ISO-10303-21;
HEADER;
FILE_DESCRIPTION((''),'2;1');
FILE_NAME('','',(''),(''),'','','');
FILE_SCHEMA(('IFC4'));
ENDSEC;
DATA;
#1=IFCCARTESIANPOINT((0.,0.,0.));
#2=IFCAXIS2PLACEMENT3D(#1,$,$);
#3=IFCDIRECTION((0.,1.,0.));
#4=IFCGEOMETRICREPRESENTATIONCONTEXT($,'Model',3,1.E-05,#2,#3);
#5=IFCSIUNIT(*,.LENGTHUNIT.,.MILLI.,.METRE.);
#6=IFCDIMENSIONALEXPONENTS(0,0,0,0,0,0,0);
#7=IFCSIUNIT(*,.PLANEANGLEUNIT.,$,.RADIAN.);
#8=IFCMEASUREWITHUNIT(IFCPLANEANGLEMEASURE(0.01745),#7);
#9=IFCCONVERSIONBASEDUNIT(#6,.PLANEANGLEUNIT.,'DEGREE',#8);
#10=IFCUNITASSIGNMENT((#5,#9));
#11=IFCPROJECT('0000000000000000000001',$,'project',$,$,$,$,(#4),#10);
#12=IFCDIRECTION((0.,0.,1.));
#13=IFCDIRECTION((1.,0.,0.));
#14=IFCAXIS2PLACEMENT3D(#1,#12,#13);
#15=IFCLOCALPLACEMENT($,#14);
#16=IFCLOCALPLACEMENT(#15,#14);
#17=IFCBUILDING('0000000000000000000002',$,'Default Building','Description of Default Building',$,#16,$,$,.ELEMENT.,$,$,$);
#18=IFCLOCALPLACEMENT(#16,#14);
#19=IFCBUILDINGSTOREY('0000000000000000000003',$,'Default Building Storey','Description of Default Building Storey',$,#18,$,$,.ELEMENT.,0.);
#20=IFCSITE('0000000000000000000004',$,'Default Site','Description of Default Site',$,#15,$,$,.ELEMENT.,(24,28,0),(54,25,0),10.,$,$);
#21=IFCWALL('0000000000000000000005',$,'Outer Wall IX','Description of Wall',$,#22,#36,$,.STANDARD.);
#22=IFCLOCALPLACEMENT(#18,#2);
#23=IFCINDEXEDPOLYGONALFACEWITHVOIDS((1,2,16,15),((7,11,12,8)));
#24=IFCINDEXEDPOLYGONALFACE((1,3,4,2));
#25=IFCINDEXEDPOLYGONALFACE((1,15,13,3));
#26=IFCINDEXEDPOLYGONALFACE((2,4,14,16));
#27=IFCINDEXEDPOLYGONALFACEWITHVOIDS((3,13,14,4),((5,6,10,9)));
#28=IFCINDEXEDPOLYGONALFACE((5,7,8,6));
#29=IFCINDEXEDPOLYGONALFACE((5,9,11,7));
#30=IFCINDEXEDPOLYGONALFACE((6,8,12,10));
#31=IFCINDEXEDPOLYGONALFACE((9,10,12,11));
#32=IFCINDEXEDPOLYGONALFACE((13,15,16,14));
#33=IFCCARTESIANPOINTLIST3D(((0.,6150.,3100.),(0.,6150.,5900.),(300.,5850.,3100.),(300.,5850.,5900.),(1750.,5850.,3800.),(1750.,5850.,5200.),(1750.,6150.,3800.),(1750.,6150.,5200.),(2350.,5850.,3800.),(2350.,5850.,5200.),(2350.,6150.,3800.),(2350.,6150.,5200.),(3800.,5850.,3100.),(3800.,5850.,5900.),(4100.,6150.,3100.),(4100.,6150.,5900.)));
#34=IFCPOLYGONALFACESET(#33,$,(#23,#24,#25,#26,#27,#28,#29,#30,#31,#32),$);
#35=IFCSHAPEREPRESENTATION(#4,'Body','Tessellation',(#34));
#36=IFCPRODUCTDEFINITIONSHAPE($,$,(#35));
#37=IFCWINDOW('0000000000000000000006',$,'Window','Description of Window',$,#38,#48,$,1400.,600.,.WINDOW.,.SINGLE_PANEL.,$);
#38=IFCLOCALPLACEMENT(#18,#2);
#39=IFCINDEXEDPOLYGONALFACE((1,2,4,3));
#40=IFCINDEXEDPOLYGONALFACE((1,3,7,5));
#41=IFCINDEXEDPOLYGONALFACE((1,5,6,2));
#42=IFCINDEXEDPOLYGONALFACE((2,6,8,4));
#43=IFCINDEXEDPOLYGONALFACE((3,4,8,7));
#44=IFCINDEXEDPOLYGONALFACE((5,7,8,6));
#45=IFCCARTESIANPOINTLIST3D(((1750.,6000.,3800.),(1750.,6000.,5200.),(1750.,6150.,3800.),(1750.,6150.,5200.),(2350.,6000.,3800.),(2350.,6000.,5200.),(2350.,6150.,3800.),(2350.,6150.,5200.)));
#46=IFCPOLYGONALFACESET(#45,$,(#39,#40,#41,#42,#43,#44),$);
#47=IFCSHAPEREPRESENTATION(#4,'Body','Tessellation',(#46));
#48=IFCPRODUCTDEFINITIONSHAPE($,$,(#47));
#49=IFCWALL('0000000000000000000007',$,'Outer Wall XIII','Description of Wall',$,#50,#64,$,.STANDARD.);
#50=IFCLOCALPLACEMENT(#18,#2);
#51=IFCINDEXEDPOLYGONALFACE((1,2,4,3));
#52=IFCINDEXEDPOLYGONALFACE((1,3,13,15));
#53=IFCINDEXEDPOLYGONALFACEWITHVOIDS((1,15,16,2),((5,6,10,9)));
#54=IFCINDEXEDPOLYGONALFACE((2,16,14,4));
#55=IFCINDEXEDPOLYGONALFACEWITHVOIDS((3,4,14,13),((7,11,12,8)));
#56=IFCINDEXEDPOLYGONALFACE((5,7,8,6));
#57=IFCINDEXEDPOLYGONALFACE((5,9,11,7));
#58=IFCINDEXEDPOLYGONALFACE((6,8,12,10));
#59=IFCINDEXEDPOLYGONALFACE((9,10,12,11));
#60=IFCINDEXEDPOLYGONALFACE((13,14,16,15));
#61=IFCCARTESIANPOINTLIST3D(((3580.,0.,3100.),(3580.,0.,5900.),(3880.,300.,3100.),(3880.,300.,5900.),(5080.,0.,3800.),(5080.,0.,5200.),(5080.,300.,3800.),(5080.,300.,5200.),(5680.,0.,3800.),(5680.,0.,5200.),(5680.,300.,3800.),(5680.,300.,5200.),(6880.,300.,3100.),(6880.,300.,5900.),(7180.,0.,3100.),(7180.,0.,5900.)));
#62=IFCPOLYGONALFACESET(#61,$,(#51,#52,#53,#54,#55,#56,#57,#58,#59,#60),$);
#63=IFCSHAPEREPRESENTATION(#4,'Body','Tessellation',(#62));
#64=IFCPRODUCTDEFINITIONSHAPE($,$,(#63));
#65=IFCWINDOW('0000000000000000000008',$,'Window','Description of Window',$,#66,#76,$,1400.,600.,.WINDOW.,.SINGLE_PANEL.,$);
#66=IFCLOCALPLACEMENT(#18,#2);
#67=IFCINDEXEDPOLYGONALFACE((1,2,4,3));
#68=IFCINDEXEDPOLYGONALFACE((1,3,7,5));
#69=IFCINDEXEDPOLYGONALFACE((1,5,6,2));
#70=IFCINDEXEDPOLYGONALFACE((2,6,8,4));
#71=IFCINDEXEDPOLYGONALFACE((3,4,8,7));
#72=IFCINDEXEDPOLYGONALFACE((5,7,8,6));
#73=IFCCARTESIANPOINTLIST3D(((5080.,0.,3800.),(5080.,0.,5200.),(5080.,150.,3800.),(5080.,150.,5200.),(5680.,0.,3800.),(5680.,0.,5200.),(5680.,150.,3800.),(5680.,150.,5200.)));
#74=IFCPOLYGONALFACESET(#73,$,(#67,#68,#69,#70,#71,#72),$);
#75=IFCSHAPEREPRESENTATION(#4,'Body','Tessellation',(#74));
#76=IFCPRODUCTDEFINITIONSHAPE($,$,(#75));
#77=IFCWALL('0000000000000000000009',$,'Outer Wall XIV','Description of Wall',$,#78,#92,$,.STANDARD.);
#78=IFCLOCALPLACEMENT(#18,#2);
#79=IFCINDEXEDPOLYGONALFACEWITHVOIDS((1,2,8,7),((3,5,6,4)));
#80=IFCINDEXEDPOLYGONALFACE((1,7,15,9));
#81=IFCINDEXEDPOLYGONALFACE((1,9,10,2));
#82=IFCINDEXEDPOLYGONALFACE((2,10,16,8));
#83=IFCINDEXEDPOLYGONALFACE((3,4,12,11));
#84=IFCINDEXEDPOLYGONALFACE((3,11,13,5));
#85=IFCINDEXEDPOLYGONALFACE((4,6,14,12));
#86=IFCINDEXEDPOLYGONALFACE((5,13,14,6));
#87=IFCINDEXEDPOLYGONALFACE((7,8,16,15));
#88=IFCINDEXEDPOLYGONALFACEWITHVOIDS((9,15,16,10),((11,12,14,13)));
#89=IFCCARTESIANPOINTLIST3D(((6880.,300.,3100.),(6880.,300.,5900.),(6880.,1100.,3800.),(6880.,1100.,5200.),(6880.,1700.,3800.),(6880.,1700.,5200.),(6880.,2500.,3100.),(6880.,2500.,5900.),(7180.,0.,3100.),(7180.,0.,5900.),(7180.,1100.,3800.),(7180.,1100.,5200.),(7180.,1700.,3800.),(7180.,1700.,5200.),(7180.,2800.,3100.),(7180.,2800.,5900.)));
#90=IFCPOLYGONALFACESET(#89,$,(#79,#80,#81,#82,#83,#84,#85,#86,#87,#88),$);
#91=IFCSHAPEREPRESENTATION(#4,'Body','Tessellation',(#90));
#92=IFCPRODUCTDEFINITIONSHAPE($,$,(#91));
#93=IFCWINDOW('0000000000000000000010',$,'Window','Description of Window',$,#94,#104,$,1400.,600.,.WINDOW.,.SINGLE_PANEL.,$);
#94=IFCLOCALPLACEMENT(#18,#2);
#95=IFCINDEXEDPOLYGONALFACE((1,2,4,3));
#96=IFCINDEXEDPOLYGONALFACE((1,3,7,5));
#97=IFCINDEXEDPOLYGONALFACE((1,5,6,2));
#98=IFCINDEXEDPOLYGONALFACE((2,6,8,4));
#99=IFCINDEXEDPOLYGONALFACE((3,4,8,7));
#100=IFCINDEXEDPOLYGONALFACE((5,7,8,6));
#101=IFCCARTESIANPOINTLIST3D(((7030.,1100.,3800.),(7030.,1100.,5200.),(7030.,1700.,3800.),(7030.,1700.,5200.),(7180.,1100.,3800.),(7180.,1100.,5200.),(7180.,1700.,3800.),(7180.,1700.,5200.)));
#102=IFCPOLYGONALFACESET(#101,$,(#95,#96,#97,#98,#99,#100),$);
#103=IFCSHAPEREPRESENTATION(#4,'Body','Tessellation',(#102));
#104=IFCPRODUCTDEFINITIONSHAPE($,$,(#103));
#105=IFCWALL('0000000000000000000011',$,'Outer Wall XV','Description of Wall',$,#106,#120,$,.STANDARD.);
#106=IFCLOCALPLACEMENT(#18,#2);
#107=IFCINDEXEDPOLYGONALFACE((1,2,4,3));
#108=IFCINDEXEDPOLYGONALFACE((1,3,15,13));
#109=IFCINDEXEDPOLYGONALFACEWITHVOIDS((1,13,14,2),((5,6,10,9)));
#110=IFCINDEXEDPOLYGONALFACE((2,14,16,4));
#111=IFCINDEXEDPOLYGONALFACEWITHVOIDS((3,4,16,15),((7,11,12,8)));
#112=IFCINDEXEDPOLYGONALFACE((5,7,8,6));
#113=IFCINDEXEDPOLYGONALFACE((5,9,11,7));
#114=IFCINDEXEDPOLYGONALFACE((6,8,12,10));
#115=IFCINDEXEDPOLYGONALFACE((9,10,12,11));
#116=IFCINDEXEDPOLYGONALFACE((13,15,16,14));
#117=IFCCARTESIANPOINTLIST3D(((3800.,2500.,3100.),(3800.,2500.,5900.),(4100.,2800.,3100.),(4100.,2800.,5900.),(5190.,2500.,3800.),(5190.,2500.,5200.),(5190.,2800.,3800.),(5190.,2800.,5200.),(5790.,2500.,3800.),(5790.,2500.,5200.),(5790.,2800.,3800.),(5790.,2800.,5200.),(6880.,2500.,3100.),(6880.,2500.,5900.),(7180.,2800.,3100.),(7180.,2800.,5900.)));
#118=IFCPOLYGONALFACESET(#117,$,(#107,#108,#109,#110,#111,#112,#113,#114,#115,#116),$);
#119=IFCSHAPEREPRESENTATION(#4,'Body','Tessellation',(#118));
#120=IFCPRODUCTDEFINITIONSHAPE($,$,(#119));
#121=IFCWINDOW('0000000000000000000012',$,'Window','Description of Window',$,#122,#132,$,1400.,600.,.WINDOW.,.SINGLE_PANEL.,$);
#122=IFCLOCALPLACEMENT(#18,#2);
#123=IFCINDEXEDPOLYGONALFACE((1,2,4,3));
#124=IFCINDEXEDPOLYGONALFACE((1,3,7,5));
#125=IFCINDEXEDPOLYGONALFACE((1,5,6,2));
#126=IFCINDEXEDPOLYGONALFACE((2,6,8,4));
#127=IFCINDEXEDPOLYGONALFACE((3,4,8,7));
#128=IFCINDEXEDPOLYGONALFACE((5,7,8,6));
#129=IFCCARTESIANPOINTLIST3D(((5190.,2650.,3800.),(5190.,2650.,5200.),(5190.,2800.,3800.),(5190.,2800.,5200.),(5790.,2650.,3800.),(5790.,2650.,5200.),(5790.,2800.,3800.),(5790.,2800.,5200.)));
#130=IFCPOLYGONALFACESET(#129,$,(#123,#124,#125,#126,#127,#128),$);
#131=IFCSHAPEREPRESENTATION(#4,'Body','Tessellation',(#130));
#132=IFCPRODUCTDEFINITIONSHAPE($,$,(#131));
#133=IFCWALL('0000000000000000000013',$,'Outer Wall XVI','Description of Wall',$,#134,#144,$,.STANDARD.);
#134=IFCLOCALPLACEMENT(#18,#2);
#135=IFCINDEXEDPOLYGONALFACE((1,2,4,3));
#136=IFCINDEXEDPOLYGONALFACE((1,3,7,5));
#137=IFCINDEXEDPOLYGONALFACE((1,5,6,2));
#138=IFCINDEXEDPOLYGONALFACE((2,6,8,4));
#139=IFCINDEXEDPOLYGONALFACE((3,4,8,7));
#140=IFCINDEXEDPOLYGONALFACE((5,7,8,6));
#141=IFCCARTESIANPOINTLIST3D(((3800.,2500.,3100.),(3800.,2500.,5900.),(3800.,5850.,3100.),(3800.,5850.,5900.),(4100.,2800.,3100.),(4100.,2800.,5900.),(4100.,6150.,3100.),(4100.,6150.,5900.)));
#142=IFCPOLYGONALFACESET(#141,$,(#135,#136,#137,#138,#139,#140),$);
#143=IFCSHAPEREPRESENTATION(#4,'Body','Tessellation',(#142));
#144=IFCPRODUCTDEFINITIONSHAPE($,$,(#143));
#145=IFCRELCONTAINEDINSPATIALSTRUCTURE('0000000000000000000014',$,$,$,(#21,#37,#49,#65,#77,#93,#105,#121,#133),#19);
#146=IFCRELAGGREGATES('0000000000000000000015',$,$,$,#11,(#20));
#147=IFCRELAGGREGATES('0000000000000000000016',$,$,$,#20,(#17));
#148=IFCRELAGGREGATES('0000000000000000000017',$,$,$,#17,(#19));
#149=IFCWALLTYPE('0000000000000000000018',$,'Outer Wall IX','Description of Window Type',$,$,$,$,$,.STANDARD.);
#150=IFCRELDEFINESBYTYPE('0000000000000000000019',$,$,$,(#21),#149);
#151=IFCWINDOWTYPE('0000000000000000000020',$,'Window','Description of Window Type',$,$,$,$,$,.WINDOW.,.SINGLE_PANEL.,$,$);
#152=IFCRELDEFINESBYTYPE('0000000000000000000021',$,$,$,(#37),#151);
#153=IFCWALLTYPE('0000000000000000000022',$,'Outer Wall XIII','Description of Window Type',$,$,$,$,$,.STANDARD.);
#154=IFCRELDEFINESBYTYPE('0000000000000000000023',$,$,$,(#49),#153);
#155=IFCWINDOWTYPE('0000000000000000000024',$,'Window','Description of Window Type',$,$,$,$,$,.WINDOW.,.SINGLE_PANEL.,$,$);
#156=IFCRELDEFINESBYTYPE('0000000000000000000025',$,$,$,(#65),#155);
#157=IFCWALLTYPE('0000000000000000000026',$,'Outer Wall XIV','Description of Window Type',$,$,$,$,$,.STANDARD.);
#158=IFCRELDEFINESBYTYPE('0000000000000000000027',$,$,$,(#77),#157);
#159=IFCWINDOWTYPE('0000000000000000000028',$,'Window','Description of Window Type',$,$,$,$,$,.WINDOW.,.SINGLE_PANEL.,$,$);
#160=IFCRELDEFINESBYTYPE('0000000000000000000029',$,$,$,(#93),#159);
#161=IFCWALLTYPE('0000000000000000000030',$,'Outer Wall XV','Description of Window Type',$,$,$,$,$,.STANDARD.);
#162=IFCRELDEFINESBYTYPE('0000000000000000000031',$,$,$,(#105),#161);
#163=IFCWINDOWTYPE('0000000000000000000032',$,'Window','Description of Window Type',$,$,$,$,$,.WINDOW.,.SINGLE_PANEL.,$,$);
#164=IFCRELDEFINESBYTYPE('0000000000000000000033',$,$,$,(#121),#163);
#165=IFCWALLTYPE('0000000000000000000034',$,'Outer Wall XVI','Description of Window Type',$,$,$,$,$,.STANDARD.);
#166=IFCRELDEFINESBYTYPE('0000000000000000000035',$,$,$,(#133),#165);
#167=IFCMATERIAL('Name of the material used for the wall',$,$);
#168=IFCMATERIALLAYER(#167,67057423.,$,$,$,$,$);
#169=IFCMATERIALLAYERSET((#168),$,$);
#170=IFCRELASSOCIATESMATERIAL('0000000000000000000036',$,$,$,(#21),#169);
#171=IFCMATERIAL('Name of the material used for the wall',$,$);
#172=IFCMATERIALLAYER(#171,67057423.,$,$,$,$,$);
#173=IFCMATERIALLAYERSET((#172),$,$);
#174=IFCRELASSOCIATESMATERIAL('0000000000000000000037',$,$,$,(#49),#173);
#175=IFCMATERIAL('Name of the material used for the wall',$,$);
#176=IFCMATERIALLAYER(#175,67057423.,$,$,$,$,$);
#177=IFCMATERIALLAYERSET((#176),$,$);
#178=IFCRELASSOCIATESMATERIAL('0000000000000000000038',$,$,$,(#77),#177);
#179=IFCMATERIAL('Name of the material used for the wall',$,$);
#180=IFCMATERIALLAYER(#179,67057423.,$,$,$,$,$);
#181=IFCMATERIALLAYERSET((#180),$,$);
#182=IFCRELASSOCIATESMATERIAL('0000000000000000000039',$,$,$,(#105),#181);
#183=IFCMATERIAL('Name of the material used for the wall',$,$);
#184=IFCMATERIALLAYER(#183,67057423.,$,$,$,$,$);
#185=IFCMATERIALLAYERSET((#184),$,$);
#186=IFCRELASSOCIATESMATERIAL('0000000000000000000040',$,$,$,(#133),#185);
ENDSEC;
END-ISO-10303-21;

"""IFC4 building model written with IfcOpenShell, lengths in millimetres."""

from ifc_helpers import new_model, entity, si_unit, converted_unit, direction, frame, origin, origin_with_axes, place, context, project, spatial, polyline, outline, extrude, material, layer, layer_set, layer_usage, type_object, element, fill, save


model = new_model("IFC4")

# Units and contexts
model_context = context("Model", 3, precision=1e-05, world=origin(), true_north=direction((0.0, 1.0, 0.0)))
ifc_project = project(units=[si_unit("LENGTHUNIT", "METRE", prefix="MILLI"), converted_unit("PLANEANGLEUNIT", "DEGREE", entity("IfcPlaneAngleMeasure", 0.01745), si_unit("PLANEANGLEUNIT", "RADIAN"), dimensions=[0, 0, 0, 0, 0, 0, 0])], contexts=[model_context])

# Site, building, storey
site_placement = place(None, origin_with_axes())
site = spatial("IfcSite", under=ifc_project, at=site_placement, Name="Default Site", Description="Description of Default Site", CompositionType="ELEMENT", RefLatitude=(24, 28, 0), RefLongitude=(54, 25, 0), RefElevation=10.0)
building_placement = place(site_placement, origin_with_axes())
building = spatial("IfcBuilding", under=site, at=building_placement, Name="Default Building", Description="Description of Default Building", CompositionType="ELEMENT")
storey_placement = place(building_placement, origin_with_axes())
storey = spatial("IfcBuildingStorey", under=building, at=storey_placement, Name="Default Building Storey", Description="Description of Default Building Storey", CompositionType="ELEMENT", Elevation=0.0)

# Walls, openings, windows
ifc_material_1 = material(Name="Name of the material used for the wall")
ifc_layer_1 = layer(ifc_material_1, 67057423.0)
ifc_layer_set_1 = layer_set([ifc_layer_1])
ifc_layer_usage_1 = layer_usage(ifc_layer_set_1, "AXIS2", "POSITIVE", -33528711.5)
wall_type_1 = type_object("IfcWallType", Name="Outer Wall IX", Description="Description of Window Type", PredefinedType="STANDARD")
wall_1_placement = place(storey_placement, frame((3950.0, 6000.0, 3100.0), z_axis=(0.0, 0.0, 1.0), x_axis=(-1.0, 0.0, 0.0)))
wall_1 = element("IfcWall", 1, at=wall_1_placement, inside=storey, type_object=wall_type_1, material=ifc_layer_usage_1, Name="Outer Wall IX", Description="Description of Wall", PredefinedType="STANDARD", context=model_context, shape_type="SweptSolid", body=[
    extrude(outline(polyline([(-150.0, -150.0), (150.0, 150.0), (3650.0, 150.0), (3950.0, -150.0), (-150.0, -150.0)])), origin_with_axes(), (0.0, 0.0, 1.0), 2800.0),
])
opening_1_placement = place(wall_1_placement, frame((1600.0, -150.0, 700.0), z_axis=(0.0, 0.0, 1.0), x_axis=(1.0, 0.0, 0.0)))
opening_1 = element("IfcOpeningElement", 2, at=opening_1_placement, cuts=wall_1, context=model_context, shape_type="SweptSolid", body=[
    extrude(outline(polyline([(0.0, 0.0), (0.0, 300.0), (600.0, 300.0), (600.0, 0.0), (0.0, 0.0)])), origin_with_axes(), (0.0, 0.0, 1.0), 1400.0),
])
window_type_1 = type_object("IfcWindowType", Name="Window", Description="Description of Window Type", PartitioningType="SINGLE_PANEL", PredefinedType="WINDOW")
window_1_placement = place(opening_1_placement, origin_with_axes())
window_1 = element("IfcWindow", 3, at=window_1_placement, inside=storey, type_object=window_type_1, Name="Window", Description="Description of Window", OverallHeight=1400.0, OverallWidth=600.0, PartitioningType="SINGLE_PANEL", PredefinedType="WINDOW", context=model_context, shape_type="SweptSolid", body=[
    extrude(outline(polyline([(0.0, 0.0), (0.0, 150.0), (600.0, 150.0), (600.0, 0.0), (0.0, 0.0)])), origin_with_axes(), (0.0, 0.0, 1.0), 1400.0),
])
fill(opening_1, window_1)
ifc_material_2 = material(Name="Name of the material used for the wall")
ifc_layer_2 = layer(ifc_material_2, 67057423.0)
ifc_layer_set_2 = layer_set([ifc_layer_2])
ifc_layer_usage_2 = layer_usage(ifc_layer_set_2, "AXIS2", "POSITIVE", -33528711.5)
wall_type_2 = type_object("IfcWallType", Name="Outer Wall XIII", Description="Description of Window Type", PredefinedType="STANDARD")
wall_2_placement = place(storey_placement, frame((3730.0, 150.0, 3100.0), z_axis=(0.0, 0.0, 1.0), x_axis=(1.0, 0.0, 0.0)))
wall_2 = element("IfcWall", 4, at=wall_2_placement, inside=storey, type_object=wall_type_2, material=ifc_layer_usage_2, Name="Outer Wall XIII", Description="Description of Wall", PredefinedType="STANDARD", context=model_context, shape_type="SweptSolid", body=[
    extrude(outline(polyline([(-150.0, -150.0), (150.0, 150.0), (3150.0, 150.0), (3450.0, -150.0), (-150.0, -150.0)])), origin_with_axes(), (0.0, 0.0, 1.0), 2800.0),
])
opening_2_placement = place(wall_2_placement, frame((1350.0, -150.0, 700.0), z_axis=(0.0, 0.0, 1.0), x_axis=(1.0, 0.0, 0.0)))
opening_2 = element("IfcOpeningElement", 5, at=opening_2_placement, cuts=wall_2, context=model_context, shape_type="SweptSolid", body=[
    extrude(outline(polyline([(0.0, 0.0), (0.0, 300.0), (600.0, 300.0), (600.0, 0.0), (0.0, 0.0)])), origin_with_axes(), (0.0, 0.0, 1.0), 1400.0),
])
window_type_2 = type_object("IfcWindowType", Name="Window", Description="Description of Window Type", PartitioningType="SINGLE_PANEL", PredefinedType="WINDOW")
window_2_placement = place(opening_2_placement, origin_with_axes())
window_2 = element("IfcWindow", 6, at=window_2_placement, inside=storey, type_object=window_type_2, Name="Window", Description="Description of Window", OverallHeight=1400.0, OverallWidth=600.0, PartitioningType="SINGLE_PANEL", PredefinedType="WINDOW", context=model_context, shape_type="SweptSolid", body=[
    extrude(outline(polyline([(0.0, 0.0), (0.0, 150.0), (600.0, 150.0), (600.0, 0.0), (0.0, 0.0)])), origin_with_axes(), (0.0, 0.0, 1.0), 1400.0),
])
fill(opening_2, window_2)
ifc_material_3 = material(Name="Name of the material used for the wall")
ifc_layer_3 = layer(ifc_material_3, 67057423.0)
ifc_layer_set_3 = layer_set([ifc_layer_3])
ifc_layer_usage_3 = layer_usage(ifc_layer_set_3, "AXIS2", "POSITIVE", -33528711.5)
wall_type_3 = type_object("IfcWallType", Name="Outer Wall XIV", Description="Description of Window Type", PredefinedType="STANDARD")
wall_3_placement = place(storey_placement, frame((7030.0, 150.0, 3100.0), z_axis=(0.0, 0.0, 1.0), x_axis=(0.0, 1.0, 0.0)))
wall_3 = element("IfcWall", 7, at=wall_3_placement, inside=storey, type_object=wall_type_3, material=ifc_layer_usage_3, Name="Outer Wall XIV", Description="Description of Wall", PredefinedType="STANDARD", context=model_context, shape_type="SweptSolid", body=[
    extrude(outline(polyline([(-150.0, -150.0), (150.0, 150.0), (2350.0, 150.0), (2650.0, -150.0), (-150.0, -150.0)])), origin_with_axes(), (0.0, 0.0, 1.0), 2800.0),
])
opening_3_placement = place(wall_3_placement, frame((950.0, -150.0, 700.0), z_axis=(0.0, 0.0, 1.0), x_axis=(1.0, 0.0, 0.0)))
opening_3 = element("IfcOpeningElement", 8, at=opening_3_placement, cuts=wall_3, context=model_context, shape_type="SweptSolid", body=[
    extrude(outline(polyline([(0.0, 0.0), (0.0, 300.0), (600.0, 300.0), (600.0, 0.0), (0.0, 0.0)])), origin_with_axes(), (0.0, 0.0, 1.0), 1400.0),
])
window_type_3 = type_object("IfcWindowType", Name="Window", Description="Description of Window Type", PartitioningType="SINGLE_PANEL", PredefinedType="WINDOW")
window_3_placement = place(opening_3_placement, origin_with_axes())
window_3 = element("IfcWindow", 9, at=window_3_placement, inside=storey, type_object=window_type_3, Name="Window", Description="Description of Window", OverallHeight=1400.0, OverallWidth=600.0, PartitioningType="SINGLE_PANEL", PredefinedType="WINDOW", context=model_context, shape_type="SweptSolid", body=[
    extrude(outline(polyline([(0.0, 0.0), (0.0, 150.0), (600.0, 150.0), (600.0, 0.0), (0.0, 0.0)])), origin_with_axes(), (0.0, 0.0, 1.0), 1400.0),
])
fill(opening_3, window_3)
ifc_material_4 = material(Name="Name of the material used for the wall")
ifc_layer_4 = layer(ifc_material_4, 67057423.0)
ifc_layer_set_4 = layer_set([ifc_layer_4])
ifc_layer_usage_4 = layer_usage(ifc_layer_set_4, "AXIS2", "POSITIVE", -33528711.5)
wall_type_4 = type_object("IfcWallType", Name="Outer Wall XV", Description="Description of Window Type", PredefinedType="STANDARD")
wall_4_placement = place(storey_placement, frame((7030.0, 2650.0, 3100.0), z_axis=(0.0, 0.0, 1.0), x_axis=(-1.0, 0.0, 0.0)))
wall_4 = element("IfcWall", 10, at=wall_4_placement, inside=storey, type_object=wall_type_4, material=ifc_layer_usage_4, Name="Outer Wall XV", Description="Description of Wall", PredefinedType="STANDARD", context=model_context, shape_type="SweptSolid", body=[
    extrude(outline(polyline([(-150.0, -150.0), (150.0, 150.0), (3230.0, 150.0), (2930.0, -150.0), (-150.0, -150.0)])), origin_with_axes(), (0.0, 0.0, 1.0), 2800.0),
])
opening_4_placement = place(wall_4_placement, frame((1240.0, -150.0, 700.0), z_axis=(0.0, 0.0, 1.0), x_axis=(1.0, 0.0, 0.0)))
opening_4 = element("IfcOpeningElement", 11, at=opening_4_placement, cuts=wall_4, context=model_context, shape_type="SweptSolid", body=[
    extrude(outline(polyline([(0.0, 0.0), (0.0, 300.0), (600.0, 300.0), (600.0, 0.0), (0.0, 0.0)])), origin_with_axes(), (0.0, 0.0, 1.0), 1400.0),
])
window_type_4 = type_object("IfcWindowType", Name="Window", Description="Description of Window Type", PartitioningType="SINGLE_PANEL", PredefinedType="WINDOW")
window_4_placement = place(opening_4_placement, origin_with_axes())
window_4 = element("IfcWindow", 12, at=window_4_placement, inside=storey, type_object=window_type_4, Name="Window", Description="Description of Window", OverallHeight=1400.0, OverallWidth=600.0, PartitioningType="SINGLE_PANEL", PredefinedType="WINDOW", context=model_context, shape_type="SweptSolid", body=[
    extrude(outline(polyline([(0.0, 0.0), (0.0, 150.0), (600.0, 150.0), (600.0, 0.0), (0.0, 0.0)])), origin_with_axes(), (0.0, 0.0, 1.0), 1400.0),
])
fill(opening_4, window_4)

# Wall
ifc_material_5 = material(Name="Name of the material used for the wall")
ifc_layer_5 = layer(ifc_material_5, 67057423.0)
ifc_layer_set_5 = layer_set([ifc_layer_5])
ifc_layer_usage_5 = layer_usage(ifc_layer_set_5, "AXIS2", "POSITIVE", -33528711.5)
wall_type_5 = type_object("IfcWallType", Name="Outer Wall XVI", Description="Description of Window Type", PredefinedType="STANDARD")
wall_5_placement = place(storey_placement, frame((3950.0, 2650.0, 3100.0), z_axis=(0.0, 0.0, 1.0), x_axis=(0.0, 1.0, 0.0)))
element("IfcWall", 13, at=wall_5_placement, inside=storey, type_object=wall_type_5, material=ifc_layer_usage_5, Name="Outer Wall XVI", Description="Description of Wall", PredefinedType="STANDARD", context=model_context, shape_type="SweptSolid", body=[
    extrude(outline(polyline([(150.0, -150.0), (-150.0, 150.0), (3200.0, 150.0), (3500.0, -150.0), (150.0, -150.0)])), origin_with_axes(), (0.0, 0.0, 1.0), 2800.0),
])

save(model, "model.ifc")
